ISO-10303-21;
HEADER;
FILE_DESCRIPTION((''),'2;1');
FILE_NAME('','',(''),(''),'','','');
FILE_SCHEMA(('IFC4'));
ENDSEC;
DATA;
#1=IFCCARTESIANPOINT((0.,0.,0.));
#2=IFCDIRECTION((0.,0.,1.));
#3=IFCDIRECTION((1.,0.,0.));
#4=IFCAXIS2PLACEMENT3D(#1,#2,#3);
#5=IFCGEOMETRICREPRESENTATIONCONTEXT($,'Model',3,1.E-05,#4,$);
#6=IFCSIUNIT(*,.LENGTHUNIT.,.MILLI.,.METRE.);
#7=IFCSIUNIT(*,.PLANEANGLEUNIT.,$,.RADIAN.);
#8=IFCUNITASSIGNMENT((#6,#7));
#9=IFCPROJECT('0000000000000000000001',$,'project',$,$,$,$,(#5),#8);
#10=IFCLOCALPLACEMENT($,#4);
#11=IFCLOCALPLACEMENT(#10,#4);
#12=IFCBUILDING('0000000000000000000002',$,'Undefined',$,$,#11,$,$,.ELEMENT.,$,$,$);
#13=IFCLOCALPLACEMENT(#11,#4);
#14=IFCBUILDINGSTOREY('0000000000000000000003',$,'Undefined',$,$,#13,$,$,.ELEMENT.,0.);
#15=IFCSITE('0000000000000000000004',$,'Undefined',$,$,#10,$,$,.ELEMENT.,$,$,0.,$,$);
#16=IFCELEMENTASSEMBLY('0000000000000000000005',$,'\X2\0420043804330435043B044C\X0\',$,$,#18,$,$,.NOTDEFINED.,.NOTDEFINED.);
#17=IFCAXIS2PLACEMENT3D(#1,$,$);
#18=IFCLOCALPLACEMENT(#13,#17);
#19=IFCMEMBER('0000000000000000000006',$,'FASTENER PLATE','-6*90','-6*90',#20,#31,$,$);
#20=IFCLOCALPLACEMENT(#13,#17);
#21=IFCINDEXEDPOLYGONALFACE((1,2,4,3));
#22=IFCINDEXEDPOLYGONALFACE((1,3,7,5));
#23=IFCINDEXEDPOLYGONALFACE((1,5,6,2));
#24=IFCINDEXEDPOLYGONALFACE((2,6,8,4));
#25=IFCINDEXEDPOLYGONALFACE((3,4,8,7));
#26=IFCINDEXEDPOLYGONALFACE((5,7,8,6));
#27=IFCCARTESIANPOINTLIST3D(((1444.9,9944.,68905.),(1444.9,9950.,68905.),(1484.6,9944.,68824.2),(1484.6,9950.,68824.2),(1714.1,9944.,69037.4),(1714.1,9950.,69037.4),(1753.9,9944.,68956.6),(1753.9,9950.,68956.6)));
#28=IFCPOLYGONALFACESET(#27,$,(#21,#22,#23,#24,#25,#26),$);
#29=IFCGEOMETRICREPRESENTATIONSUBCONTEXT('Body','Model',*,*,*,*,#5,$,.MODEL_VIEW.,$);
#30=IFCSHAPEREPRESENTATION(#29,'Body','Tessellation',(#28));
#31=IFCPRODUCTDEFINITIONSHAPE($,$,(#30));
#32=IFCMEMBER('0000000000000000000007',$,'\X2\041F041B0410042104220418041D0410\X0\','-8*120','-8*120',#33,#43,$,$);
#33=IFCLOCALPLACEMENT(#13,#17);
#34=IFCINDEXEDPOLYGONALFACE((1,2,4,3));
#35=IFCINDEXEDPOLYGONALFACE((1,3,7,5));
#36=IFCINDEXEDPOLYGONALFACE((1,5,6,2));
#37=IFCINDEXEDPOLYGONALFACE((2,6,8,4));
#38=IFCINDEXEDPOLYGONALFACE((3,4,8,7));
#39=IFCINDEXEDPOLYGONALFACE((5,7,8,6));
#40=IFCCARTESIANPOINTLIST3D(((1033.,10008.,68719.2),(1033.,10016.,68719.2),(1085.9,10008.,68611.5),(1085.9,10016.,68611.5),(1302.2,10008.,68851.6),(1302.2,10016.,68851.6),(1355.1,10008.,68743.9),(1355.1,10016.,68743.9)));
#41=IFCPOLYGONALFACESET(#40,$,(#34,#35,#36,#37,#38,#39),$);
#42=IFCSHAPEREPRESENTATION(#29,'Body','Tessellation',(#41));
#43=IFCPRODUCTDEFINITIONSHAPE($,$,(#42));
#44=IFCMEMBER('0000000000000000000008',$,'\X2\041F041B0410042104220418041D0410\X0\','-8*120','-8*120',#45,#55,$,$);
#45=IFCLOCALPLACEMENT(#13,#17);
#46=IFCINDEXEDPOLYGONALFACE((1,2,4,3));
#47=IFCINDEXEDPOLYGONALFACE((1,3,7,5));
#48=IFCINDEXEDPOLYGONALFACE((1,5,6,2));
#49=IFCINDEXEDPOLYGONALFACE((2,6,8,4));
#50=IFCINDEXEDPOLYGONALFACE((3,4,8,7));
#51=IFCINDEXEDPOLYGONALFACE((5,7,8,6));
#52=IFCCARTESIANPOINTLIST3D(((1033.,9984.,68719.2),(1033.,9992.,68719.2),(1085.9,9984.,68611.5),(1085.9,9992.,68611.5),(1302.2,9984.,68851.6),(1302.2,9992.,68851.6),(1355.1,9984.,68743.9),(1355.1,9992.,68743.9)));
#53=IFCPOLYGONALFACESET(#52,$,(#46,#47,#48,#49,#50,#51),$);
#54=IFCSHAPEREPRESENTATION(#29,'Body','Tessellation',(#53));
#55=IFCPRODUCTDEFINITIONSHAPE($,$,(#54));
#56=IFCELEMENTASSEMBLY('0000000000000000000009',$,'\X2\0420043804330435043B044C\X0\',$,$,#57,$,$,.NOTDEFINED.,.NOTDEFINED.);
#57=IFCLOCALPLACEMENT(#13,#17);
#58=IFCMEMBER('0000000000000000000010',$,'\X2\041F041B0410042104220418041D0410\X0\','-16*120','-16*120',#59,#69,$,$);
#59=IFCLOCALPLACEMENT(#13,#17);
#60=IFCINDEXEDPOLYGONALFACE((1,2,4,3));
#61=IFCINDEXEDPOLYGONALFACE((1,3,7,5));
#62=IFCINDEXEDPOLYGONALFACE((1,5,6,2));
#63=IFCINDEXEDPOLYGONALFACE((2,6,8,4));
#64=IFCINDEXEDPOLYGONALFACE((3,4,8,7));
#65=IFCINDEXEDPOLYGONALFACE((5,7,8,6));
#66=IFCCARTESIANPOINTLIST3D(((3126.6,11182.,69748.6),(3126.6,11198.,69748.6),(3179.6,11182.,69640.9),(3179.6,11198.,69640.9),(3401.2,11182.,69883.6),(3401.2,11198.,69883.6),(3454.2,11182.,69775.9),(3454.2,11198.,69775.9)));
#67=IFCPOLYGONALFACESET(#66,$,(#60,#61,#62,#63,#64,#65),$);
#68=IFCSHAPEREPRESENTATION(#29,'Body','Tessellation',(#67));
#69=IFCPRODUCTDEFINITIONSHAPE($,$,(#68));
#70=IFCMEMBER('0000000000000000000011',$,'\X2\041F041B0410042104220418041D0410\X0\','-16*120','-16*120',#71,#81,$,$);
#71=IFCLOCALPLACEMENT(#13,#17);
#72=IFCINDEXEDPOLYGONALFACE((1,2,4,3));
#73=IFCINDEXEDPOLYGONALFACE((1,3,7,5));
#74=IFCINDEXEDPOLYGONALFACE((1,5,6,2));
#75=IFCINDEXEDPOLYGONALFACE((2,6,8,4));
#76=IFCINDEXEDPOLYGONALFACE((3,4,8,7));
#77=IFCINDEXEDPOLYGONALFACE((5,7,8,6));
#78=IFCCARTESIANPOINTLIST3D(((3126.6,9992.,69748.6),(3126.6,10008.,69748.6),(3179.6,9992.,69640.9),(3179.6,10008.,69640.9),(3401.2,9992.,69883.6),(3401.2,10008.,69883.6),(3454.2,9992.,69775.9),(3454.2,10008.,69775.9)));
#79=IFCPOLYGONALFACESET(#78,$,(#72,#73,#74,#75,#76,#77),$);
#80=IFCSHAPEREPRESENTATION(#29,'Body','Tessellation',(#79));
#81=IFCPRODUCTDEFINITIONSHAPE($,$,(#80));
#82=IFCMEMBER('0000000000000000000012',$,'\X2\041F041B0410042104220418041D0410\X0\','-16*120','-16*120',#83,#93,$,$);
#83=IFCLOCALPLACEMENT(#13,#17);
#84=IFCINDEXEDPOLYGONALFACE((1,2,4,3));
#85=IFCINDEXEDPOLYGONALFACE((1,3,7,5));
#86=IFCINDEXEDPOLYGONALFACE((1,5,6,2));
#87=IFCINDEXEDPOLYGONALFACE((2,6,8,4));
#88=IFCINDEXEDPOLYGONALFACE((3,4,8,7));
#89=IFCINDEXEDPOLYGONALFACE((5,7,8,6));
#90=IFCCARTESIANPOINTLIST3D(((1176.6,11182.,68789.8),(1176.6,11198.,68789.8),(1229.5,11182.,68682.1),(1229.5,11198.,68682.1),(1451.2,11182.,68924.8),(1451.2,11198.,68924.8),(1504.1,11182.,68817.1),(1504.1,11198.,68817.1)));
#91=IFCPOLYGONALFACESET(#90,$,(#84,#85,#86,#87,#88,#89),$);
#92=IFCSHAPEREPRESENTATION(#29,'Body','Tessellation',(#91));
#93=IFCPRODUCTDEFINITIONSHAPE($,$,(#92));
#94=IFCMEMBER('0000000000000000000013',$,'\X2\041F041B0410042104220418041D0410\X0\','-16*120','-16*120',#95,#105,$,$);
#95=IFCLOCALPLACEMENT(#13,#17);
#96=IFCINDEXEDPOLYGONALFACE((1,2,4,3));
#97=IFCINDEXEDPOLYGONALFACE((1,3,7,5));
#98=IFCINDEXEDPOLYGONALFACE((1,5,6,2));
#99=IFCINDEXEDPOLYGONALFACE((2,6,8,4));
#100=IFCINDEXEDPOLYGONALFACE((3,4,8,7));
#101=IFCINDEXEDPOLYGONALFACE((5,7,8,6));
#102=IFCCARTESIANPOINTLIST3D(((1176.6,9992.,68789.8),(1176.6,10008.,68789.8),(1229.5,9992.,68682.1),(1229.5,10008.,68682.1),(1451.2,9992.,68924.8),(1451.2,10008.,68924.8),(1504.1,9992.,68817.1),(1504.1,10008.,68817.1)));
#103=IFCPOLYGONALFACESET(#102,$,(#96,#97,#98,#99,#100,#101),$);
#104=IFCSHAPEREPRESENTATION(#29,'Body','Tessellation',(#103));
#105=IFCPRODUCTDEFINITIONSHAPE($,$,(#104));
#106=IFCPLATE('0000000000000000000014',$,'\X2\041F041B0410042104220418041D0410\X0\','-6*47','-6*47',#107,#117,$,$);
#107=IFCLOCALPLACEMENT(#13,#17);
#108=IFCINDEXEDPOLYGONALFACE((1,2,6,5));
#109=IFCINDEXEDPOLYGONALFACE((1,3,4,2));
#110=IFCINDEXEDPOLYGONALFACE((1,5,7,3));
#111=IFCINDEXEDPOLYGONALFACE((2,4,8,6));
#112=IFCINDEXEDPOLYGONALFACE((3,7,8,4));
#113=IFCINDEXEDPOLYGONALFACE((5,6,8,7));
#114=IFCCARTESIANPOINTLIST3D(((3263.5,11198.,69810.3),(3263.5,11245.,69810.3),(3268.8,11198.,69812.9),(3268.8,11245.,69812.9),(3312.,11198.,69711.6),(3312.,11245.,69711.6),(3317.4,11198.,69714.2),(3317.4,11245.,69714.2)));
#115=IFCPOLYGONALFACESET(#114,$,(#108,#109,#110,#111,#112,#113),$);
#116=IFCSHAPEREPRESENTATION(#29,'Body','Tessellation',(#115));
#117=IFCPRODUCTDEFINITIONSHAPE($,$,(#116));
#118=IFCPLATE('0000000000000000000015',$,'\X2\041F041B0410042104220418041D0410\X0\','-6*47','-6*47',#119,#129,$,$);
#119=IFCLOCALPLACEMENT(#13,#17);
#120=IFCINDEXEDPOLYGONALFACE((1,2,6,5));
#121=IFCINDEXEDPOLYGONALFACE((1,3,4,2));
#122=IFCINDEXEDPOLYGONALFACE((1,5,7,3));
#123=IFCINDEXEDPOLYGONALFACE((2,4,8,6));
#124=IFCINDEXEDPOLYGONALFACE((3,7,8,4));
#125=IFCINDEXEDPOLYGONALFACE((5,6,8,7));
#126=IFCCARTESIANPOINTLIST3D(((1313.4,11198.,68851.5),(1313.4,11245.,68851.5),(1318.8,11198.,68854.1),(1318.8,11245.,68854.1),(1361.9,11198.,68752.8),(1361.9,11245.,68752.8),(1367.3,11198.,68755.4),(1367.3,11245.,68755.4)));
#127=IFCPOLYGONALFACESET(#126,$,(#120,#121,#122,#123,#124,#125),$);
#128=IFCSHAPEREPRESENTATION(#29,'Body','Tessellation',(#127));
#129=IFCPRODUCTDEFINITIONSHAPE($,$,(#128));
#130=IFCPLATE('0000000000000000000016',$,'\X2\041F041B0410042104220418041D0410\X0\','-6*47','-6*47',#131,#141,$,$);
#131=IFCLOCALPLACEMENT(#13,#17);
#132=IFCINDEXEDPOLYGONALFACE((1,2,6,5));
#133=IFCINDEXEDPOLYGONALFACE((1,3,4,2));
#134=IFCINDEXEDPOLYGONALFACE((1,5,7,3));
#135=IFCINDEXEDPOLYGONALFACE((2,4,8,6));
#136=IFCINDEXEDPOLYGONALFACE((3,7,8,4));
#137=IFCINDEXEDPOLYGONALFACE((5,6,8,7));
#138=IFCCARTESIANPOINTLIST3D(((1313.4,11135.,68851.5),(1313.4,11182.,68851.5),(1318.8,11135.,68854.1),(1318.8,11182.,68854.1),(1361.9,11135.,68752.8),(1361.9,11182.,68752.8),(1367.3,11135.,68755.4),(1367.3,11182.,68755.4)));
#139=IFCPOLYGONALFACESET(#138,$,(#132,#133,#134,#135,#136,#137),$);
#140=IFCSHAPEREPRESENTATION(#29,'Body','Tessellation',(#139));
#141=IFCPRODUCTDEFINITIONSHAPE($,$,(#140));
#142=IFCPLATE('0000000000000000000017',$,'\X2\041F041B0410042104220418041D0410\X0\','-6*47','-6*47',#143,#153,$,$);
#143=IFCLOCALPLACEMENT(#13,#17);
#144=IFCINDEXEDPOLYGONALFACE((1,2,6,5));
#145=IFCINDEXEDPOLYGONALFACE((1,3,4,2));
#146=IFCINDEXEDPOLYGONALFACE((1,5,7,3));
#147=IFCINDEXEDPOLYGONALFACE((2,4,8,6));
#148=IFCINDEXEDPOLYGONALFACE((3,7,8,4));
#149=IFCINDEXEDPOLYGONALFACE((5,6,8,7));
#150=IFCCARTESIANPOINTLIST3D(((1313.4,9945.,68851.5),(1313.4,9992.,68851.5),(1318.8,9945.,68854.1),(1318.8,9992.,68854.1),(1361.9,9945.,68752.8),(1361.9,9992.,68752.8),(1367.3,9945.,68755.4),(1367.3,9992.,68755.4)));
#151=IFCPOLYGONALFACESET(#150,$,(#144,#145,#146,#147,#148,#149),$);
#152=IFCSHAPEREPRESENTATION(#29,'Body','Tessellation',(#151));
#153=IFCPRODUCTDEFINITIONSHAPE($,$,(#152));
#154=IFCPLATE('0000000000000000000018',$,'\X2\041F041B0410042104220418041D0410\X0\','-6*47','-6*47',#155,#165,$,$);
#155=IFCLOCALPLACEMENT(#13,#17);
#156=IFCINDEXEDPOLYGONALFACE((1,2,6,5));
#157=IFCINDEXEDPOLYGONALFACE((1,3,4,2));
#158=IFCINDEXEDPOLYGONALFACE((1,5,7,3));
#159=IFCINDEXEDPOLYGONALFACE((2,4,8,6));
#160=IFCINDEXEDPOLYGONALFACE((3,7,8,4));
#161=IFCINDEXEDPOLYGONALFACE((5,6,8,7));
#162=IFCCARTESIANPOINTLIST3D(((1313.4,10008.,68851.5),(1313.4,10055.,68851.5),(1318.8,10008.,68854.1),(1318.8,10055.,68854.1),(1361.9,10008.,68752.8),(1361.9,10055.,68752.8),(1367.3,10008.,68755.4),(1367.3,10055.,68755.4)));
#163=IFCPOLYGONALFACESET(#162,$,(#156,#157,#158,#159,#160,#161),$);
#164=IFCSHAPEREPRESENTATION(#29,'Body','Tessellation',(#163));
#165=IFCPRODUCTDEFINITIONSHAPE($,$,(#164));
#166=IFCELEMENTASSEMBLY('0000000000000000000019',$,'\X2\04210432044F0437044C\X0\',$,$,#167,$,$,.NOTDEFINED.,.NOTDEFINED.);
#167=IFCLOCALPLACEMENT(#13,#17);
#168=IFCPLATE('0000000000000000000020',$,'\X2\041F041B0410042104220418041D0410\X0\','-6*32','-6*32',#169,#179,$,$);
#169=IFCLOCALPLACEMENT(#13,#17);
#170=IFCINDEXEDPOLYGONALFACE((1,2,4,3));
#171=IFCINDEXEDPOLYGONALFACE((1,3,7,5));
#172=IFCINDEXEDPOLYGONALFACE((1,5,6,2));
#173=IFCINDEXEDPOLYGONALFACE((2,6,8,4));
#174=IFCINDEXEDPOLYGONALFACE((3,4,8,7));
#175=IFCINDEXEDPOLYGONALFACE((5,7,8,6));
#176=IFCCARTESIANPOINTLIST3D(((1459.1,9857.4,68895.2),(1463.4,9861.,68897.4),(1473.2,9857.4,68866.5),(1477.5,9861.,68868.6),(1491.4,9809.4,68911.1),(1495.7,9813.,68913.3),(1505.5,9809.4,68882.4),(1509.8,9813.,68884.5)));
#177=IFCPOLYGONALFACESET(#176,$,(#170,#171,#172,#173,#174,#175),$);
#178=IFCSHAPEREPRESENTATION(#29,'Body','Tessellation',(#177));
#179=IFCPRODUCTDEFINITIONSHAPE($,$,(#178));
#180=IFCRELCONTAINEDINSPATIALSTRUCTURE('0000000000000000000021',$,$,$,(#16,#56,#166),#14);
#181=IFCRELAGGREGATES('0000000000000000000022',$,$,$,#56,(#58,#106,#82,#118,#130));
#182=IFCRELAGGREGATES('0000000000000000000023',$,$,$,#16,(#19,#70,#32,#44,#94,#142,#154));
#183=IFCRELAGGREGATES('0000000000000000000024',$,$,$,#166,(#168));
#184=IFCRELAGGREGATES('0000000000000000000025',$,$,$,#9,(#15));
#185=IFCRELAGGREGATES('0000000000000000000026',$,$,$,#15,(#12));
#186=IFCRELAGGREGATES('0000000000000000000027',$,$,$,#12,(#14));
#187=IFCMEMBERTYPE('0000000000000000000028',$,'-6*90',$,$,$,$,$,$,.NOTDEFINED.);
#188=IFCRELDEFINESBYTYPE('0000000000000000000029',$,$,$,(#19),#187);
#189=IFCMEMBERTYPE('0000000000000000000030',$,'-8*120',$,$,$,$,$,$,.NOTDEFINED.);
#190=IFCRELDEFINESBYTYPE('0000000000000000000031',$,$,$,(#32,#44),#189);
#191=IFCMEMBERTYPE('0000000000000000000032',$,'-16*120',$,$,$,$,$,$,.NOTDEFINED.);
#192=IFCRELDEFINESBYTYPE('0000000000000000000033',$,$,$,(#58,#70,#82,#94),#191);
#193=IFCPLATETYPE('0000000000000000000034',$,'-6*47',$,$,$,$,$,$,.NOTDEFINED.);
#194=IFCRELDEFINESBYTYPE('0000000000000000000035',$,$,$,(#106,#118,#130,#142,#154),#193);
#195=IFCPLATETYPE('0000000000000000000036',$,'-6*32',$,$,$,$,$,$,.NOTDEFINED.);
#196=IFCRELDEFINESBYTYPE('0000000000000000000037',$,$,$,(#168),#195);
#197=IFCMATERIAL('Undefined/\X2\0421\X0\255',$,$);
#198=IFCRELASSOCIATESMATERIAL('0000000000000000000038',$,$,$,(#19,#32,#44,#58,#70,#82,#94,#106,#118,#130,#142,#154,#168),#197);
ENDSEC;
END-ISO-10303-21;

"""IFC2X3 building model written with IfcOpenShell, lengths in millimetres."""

from ifc_helpers import new_model, si_unit, frame, origin_with_axes, origin_2d_with_axis, place, context, subcontext, project, spatial, polyline, rectangle, outline, extrude, boolean, material, type_object, element, aggregate, save


model = new_model("IFC2X3")

# Units and contexts
model_context = context("Model", 3, precision=1e-05, world=origin_with_axes())
body_context = subcontext(model_context, "Body", "Model", "MODEL_VIEW")
ifc_project = project(units=[si_unit("LENGTHUNIT", "METRE", prefix="MILLI"), si_unit("PLANEANGLEUNIT", "RADIAN")], contexts=[model_context])

# Site, building, storey
site_placement = place(None, origin_with_axes())
site = spatial("IfcSite", under=ifc_project, at=site_placement, Name="Undefined", CompositionType="ELEMENT", RefElevation=0.0)
building_placement = place(site_placement, origin_with_axes())
building = spatial("IfcBuilding", under=site, at=building_placement, Name="Undefined", CompositionType="ELEMENT")
storey_placement = place(building_placement, origin_with_axes())
storey = spatial("IfcBuildingStorey", under=building, at=storey_placement, Name="Undefined", CompositionType="ELEMENT", Elevation=0.0)

# Element assembly, members
assembly_1_placement = place(storey_placement, origin_with_axes())
assembly_1 = element("IfcElementAssembly", 1, at=assembly_1_placement, inside=storey, Name="Ригель", AssemblyPlace="NOTDEFINED", PredefinedType="NOTDEFINED")
ifc_material_1 = material(Name="Undefined/С255")
member_type_1 = type_object("IfcMemberType", Name="-6*90", PredefinedType="NOTDEFINED")
member_1_placement = place(assembly_1_placement, frame((1734.0, 9947.0, 68997.0), z_axis=(-0.441224, 0.0, 0.897397), x_axis=(-0.897397, 0.0, -0.441224)))
member_1 = element("IfcMember", 2, at=member_1_placement, type_object=member_type_1, material=ifc_material_1, Name="FASTENER PLATE", Description="-6*90", ObjectType="-6*90", context=body_context, shape_type="SweptSolid", body=[
    extrude(rectangle(XDim=6.0, YDim=90.0, at=origin_2d_with_axis()), frame((300.0, 0.0, 0.0), z_axis=(-1.0, 0.0, 0.0), x_axis=(0.0, -1.0, 0.0)), (0.0, 0.0, 1.0), 300.0),
])
member_type_2 = type_object("IfcMemberType", Name="-8*120", PredefinedType="NOTDEFINED")
member_2_placement = place(assembly_1_placement, frame((1059.5, 10012.0, 68665.3), z_axis=(0.441221, 0.0, -0.897399), x_axis=(0.897399, 0.0, 0.441221)))
member_2 = element("IfcMember", 3, at=member_2_placement, type_object=member_type_2, material=ifc_material_1, Name="ПЛАСТИНА", Description="-8*120", ObjectType="-8*120", context=body_context, shape_type="SweptSolid", body=[
    extrude(rectangle(XDim=8.0, YDim=120.0, at=origin_2d_with_axis()), frame((300.0, 0.0, 0.0), z_axis=(-1.0, 0.0, 0.0), x_axis=(0.0, -1.0, 0.0)), (0.0, 0.0, 1.0), 300.0),
])
member_3_placement = place(assembly_1_placement, frame((1059.5, 9988.0, 68665.3), z_axis=(0.441221, 0.0, -0.897399), x_axis=(0.897399, 0.0, 0.441221)))
member_3 = element("IfcMember", 4, at=member_3_placement, type_object=member_type_2, material=ifc_material_1, Name="ПЛАСТИНА", Description="-8*120", ObjectType="-8*120", context=body_context, shape_type="SweptSolid", body=[
    extrude(rectangle(XDim=8.0, YDim=120.0, at=origin_2d_with_axis()), frame((300.0, 0.0, 0.0), z_axis=(-1.0, 0.0, 0.0), x_axis=(0.0, -1.0, 0.0)), (0.0, 0.0, 1.0), 300.0),
])

# Element assembly, member
assembly_2_placement = place(storey_placement, origin_with_axes())
assembly_2 = element("IfcElementAssembly", 5, at=assembly_2_placement, inside=storey, Name="Ригель", AssemblyPlace="NOTDEFINED", PredefinedType="NOTDEFINED")
member_type_3 = type_object("IfcMemberType", Name="-16*120", PredefinedType="NOTDEFINED")
member_4_placement = place(assembly_2_placement, frame((3153.1, 11190.0, 69694.7), z_axis=(0.441221, 0.0, -0.897399), x_axis=(0.897399, 0.0, 0.441221)))
member_4 = element("IfcMember", 6, at=member_4_placement, type_object=member_type_3, material=ifc_material_1, Name="ПЛАСТИНА", Description="-16*120", ObjectType="-16*120", context=body_context, shape_type="SweptSolid", body=[
    extrude(rectangle(XDim=16.0, YDim=120.0, at=origin_2d_with_axis()), frame((306.0, 0.0, 0.0), z_axis=(-1.0, 0.0, 0.0), x_axis=(0.0, -1.0, 0.0)), (0.0, 0.0, 1.0), 306.0),
])

# Members
member_5_placement = place(assembly_1_placement, frame((3153.1, 10000.0, 69694.7), z_axis=(0.441221, 0.0, -0.897399), x_axis=(0.897399, 0.0, 0.441221)))
member_5 = element("IfcMember", 7, at=member_5_placement, type_object=member_type_3, material=ifc_material_1, Name="ПЛАСТИНА", Description="-16*120", ObjectType="-16*120", context=body_context, shape_type="SweptSolid", body=[
    extrude(rectangle(XDim=16.0, YDim=120.0, at=origin_2d_with_axis()), frame((306.0, 0.0, 0.0), z_axis=(-1.0, 0.0, 0.0), x_axis=(0.0, -1.0, 0.0)), (0.0, 0.0, 1.0), 306.0),
])
member_6_placement = place(assembly_2_placement, frame((1203.0, 11190.0, 68735.9), z_axis=(0.441221, 0.0, -0.897399), x_axis=(0.897399, 0.0, 0.441221)))
member_6 = element("IfcMember", 8, at=member_6_placement, type_object=member_type_3, material=ifc_material_1, Name="ПЛАСТИНА", Description="-16*120", ObjectType="-16*120", context=body_context, shape_type="SweptSolid", body=[
    extrude(rectangle(XDim=16.0, YDim=120.0, at=origin_2d_with_axis()), frame((306.0, 0.0, 0.0), z_axis=(-1.0, 0.0, 0.0), x_axis=(0.0, -1.0, 0.0)), (0.0, 0.0, 1.0), 306.0),
])
member_7_placement = place(assembly_1_placement, frame((1203.0, 10000.0, 68735.9), z_axis=(0.441221, 0.0, -0.897399), x_axis=(0.897399, 0.0, 0.441221)))
member_7 = element("IfcMember", 9, at=member_7_placement, type_object=member_type_3, material=ifc_material_1, Name="ПЛАСТИНА", Description="-16*120", ObjectType="-16*120", context=body_context, shape_type="SweptSolid", body=[
    extrude(rectangle(XDim=16.0, YDim=120.0, at=origin_2d_with_axis()), frame((306.0, 0.0, 0.0), z_axis=(-1.0, 0.0, 0.0), x_axis=(0.0, -1.0, 0.0)), (0.0, 0.0, 1.0), 306.0),
])

# Plates
plate_type_1 = type_object("IfcPlateType", Name="-6*47", PredefinedType="NOTDEFINED")
plate_1_placement = place(assembly_2_placement, frame((3266.1, 11135.0, 69811.6), z_axis=(0.897399, 0.0, 0.441221), x_axis=(0.441221, 0.0, -0.897399)))
plate_1 = element("IfcPlate", 10, at=plate_1_placement, type_object=plate_type_1, material=ifc_material_1, Name="ПЛАСТИНА", Description="-6*47", ObjectType="-6*47", context=body_context, shape_type="CSG", body=[
    boolean("DIFFERENCE", extrude(outline(polyline([(0.0, 0.0), (110.0, 0.0), (110.0, 110.0), (0.0, 110.0), (0.0, 0.0)])), frame((0.0, 0.0, -3.0), z_axis=(0.0, 0.0, 1.0), x_axis=(1.0, 0.0, 0.0)), (0.0, 0.0, 1.0), 6.0), extrude(rectangle(XDim=26.0, YDim=130.0, at=origin_2d_with_axis()), frame((55.0, -3.0, 0.0), z_axis=(0.0, 1.0, 0.0), x_axis=(0.0, 0.0, -1.0)), (0.0, 0.0, 1.0), 66.0)),
])
plate_2_placement = place(assembly_2_placement, frame((1364.6, 11135.0, 68754.1), z_axis=(-0.897399, 0.0, -0.441221), x_axis=(-0.441221, 0.0, 0.897399)))
plate_2 = element("IfcPlate", 11, at=plate_2_placement, type_object=plate_type_1, material=ifc_material_1, Name="ПЛАСТИНА", Description="-6*47", ObjectType="-6*47", context=body_context, shape_type="CSG", body=[
    boolean("DIFFERENCE", extrude(outline(polyline([(0.0, 0.0), (110.0, 0.0), (110.0, 110.0), (0.0, 110.0), (0.0, 0.0)])), frame((0.0, 0.0, -3.0), z_axis=(0.0, 0.0, 1.0), x_axis=(1.0, 0.0, 0.0)), (0.0, 0.0, 1.0), 6.0), extrude(rectangle(XDim=26.0, YDim=130.0, at=origin_2d_with_axis()), frame((55.0, -3.0, 0.0), z_axis=(0.0, 1.0, 0.0), x_axis=(0.0, 0.0, -1.0)), (0.0, 0.0, 1.0), 66.0)),
])
plate_3_placement = place(assembly_2_placement, frame((1364.6, 11135.0, 68754.1), z_axis=(-0.897399, 0.0, -0.441221), x_axis=(-0.441221, 0.0, 0.897399)))
plate_3 = element("IfcPlate", 12, at=plate_3_placement, type_object=plate_type_1, material=ifc_material_1, Name="ПЛАСТИНА", Description="-6*47", ObjectType="-6*47", context=body_context, shape_type="CSG", body=[
    boolean("DIFFERENCE", extrude(outline(polyline([(0.0, 0.0), (110.0, 0.0), (110.0, 110.0), (0.0, 110.0), (0.0, 0.0)])), frame((0.0, 0.0, -3.0), z_axis=(0.0, 0.0, 1.0), x_axis=(1.0, 0.0, 0.0)), (0.0, 0.0, 1.0), 6.0), extrude(rectangle(XDim=26.0, YDim=130.0, at=origin_2d_with_axis()), frame((55.0, 47.0, 0.0), z_axis=(0.0, 1.0, 0.0), x_axis=(0.0, 0.0, -1.0)), (0.0, 0.0, 1.0), 66.0)),
])
plate_4_placement = place(assembly_1_placement, frame((1364.6, 9945.0, 68754.1), z_axis=(-0.897399, 0.0, -0.441221), x_axis=(-0.441221, 0.0, 0.897399)))
plate_4 = element("IfcPlate", 13, at=plate_4_placement, type_object=plate_type_1, material=ifc_material_1, Name="ПЛАСТИНА", Description="-6*47", ObjectType="-6*47", context=body_context, shape_type="CSG", body=[
    boolean("DIFFERENCE", extrude(outline(polyline([(0.0, 0.0), (110.0, 0.0), (110.0, 110.0), (0.0, 110.0), (0.0, 0.0)])), frame((0.0, 0.0, -3.0), z_axis=(0.0, 0.0, 1.0), x_axis=(1.0, 0.0, 0.0)), (0.0, 0.0, 1.0), 6.0), extrude(rectangle(XDim=26.0, YDim=130.0, at=origin_2d_with_axis()), frame((55.0, 47.0, 0.0), z_axis=(0.0, 1.0, 0.0), x_axis=(0.0, 0.0, -1.0)), (0.0, 0.0, 1.0), 66.0)),
])
plate_5_placement = place(assembly_1_placement, frame((1364.6, 9945.0, 68754.1), z_axis=(-0.897399, 0.0, -0.441221), x_axis=(-0.441221, 0.0, 0.897399)))
plate_5 = element("IfcPlate", 14, at=plate_5_placement, type_object=plate_type_1, material=ifc_material_1, Name="ПЛАСТИНА", Description="-6*47", ObjectType="-6*47", context=body_context, shape_type="CSG", body=[
    boolean("DIFFERENCE", extrude(outline(polyline([(0.0, 0.0), (110.0, 0.0), (110.0, 110.0), (0.0, 110.0), (0.0, 0.0)])), frame((0.0, 0.0, -3.0), z_axis=(0.0, 0.0, 1.0), x_axis=(1.0, 0.0, 0.0)), (0.0, 0.0, 1.0), 6.0), extrude(rectangle(XDim=26.0, YDim=130.0, at=origin_2d_with_axis()), frame((55.0, -3.0, 0.0), z_axis=(0.0, 1.0, 0.0), x_axis=(0.0, 0.0, -1.0)), (0.0, 0.0, 1.0), 66.0)),
])

# Element assembly, plate
assembly_3_placement = place(storey_placement, origin_with_axes())
assembly_3 = element("IfcElementAssembly", 15, at=assembly_3_placement, inside=storey, Name="Связь", AssemblyPlace="NOTDEFINED", PredefinedType="NOTDEFINED")
plate_type_2 = type_object("IfcPlateType", Name="-6*32", PredefinedType="NOTDEFINED")
plate_6_placement = place(assembly_3_placement, frame((1461.2, 9859.2, 68896.3), z_axis=(-0.717731, -0.600279, -0.352884), x_axis=(0.441222, -0.000002, -0.897398)))
plate_6 = element("IfcPlate", 16, at=plate_6_placement, type_object=plate_type_2, material=ifc_material_1, Name="ПЛАСТИНА", Description="-6*32", ObjectType="-6*32", context=body_context, shape_type="SweptSolid", body=[
    extrude(outline(polyline([(0.0, 0.0), (32.0, 0.0), (32.0, 60.0), (0.0, 60.0), (0.0, 0.0)])), frame((0.0, 0.0, -3.0), z_axis=(0.0, 0.0, 1.0), x_axis=(1.0, 0.0, 0.0)), (0.0, 0.0, 1.0), 6.0),
])

aggregate(assembly_2, [member_4, plate_1, member_6, plate_2, plate_3])
aggregate(assembly_1, [member_1, member_5, member_2, member_3, member_7, plate_4, plate_5])
aggregate(assembly_3, [plate_6])

save(model, "model.ifc")
